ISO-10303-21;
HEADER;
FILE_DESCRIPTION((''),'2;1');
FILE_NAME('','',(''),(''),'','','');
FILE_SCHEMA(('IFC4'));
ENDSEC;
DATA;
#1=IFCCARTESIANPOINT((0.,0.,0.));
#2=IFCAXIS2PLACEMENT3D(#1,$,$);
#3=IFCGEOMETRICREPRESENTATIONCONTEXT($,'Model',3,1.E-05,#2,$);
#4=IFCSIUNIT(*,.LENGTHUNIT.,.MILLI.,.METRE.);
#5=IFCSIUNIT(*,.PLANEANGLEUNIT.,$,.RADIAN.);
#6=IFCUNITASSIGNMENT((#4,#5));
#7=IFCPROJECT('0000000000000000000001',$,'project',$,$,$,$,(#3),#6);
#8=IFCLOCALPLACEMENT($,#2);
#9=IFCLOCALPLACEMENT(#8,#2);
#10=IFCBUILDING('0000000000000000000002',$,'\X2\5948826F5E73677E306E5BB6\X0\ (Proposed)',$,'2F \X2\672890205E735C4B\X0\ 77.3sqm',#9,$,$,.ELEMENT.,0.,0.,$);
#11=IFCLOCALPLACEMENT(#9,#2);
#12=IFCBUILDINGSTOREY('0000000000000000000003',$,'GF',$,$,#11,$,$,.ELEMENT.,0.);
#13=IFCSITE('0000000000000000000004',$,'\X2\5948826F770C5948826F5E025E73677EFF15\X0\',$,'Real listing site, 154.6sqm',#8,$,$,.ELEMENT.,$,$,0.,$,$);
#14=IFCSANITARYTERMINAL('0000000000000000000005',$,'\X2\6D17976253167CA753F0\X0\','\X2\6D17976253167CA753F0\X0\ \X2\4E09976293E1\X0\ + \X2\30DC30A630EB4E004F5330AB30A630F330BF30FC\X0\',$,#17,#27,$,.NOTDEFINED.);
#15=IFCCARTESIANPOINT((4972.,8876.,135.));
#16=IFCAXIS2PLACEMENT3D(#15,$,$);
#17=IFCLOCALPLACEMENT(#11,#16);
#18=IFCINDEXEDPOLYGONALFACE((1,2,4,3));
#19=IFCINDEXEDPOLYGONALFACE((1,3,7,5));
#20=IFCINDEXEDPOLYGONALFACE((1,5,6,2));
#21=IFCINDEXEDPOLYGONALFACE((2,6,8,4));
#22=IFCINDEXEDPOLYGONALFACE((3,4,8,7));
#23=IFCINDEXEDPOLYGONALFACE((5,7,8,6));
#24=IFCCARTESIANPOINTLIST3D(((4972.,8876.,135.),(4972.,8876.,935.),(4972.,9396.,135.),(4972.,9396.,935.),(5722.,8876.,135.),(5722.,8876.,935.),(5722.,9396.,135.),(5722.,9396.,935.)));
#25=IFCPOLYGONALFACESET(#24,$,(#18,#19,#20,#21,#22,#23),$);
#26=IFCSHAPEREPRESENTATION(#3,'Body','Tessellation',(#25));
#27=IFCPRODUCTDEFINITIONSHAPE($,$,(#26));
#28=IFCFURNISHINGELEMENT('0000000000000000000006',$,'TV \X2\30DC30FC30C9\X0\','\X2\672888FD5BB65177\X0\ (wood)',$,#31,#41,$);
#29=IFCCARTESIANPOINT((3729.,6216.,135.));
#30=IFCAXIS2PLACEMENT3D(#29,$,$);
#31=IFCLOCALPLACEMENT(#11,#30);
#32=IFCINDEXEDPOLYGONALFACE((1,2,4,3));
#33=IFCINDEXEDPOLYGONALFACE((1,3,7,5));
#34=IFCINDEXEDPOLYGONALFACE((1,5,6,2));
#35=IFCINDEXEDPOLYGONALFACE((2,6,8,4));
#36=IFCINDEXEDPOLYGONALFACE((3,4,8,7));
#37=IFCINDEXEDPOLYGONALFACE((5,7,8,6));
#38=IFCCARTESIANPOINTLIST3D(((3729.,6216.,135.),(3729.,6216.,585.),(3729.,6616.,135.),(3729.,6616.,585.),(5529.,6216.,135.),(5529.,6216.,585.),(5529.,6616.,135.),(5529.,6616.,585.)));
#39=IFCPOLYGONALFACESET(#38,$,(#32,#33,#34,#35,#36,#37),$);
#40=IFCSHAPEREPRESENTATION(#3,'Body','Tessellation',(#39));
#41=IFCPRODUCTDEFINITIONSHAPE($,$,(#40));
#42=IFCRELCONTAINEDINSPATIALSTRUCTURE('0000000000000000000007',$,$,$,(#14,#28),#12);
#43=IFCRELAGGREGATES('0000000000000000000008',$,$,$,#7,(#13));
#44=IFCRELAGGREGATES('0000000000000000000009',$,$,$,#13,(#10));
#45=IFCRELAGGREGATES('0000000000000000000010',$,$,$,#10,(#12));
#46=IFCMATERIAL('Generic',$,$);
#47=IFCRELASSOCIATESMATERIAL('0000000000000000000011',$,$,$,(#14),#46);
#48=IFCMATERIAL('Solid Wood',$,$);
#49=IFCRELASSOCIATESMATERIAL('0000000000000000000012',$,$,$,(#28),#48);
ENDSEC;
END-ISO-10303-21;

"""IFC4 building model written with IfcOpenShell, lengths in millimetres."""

from ifc_helpers import new_model, si_unit, frame, frame_2d, origin, place, context, project, spatial, rectangle, extrude, material, element, save


model = new_model("IFC4")

# Units and contexts
model_context = context("Model", 3, precision=1e-05, world=origin())
ifc_project = project(units=[si_unit("LENGTHUNIT", "METRE", prefix="MILLI"), si_unit("PLANEANGLEUNIT", "RADIAN")], contexts=[model_context])

# Site, building, storey
site_placement = place(None, origin())
site = spatial("IfcSite", under=ifc_project, at=site_placement, Name="奈良県奈良市平松５", ObjectType="Real listing site, 154.6sqm", CompositionType="ELEMENT", RefElevation=0.0)
building_placement = place(site_placement, origin())
building = spatial("IfcBuilding", under=site, at=building_placement, Name="奈良平松の家 (Proposed)", ObjectType="2F 木造平屋 77.3sqm", CompositionType="ELEMENT", ElevationOfRefHeight=0.0, ElevationOfTerrain=0.0)
storey_placement = place(building_placement, origin())
storey = spatial("IfcBuildingStorey", under=building, at=storey_placement, Name="GF", CompositionType="ELEMENT", Elevation=0.0)

# Shared definitions
ifc_material_1 = material(Name="Solid Wood")

# Shared definitions
ifc_material_2 = material(Name="Generic")

# Sanitary terminal
sanitary_terminal_1_placement = place(storey_placement, frame((4972.0, 8876.0, 135.0)))
element("IfcSanitaryTerminal", 1, at=sanitary_terminal_1_placement, inside=storey, material=ifc_material_2, Name="洗面化粧台", Description="洗面化粧台 三面鏡 + ボウル一体カウンター", PredefinedType="NOTDEFINED", context=model_context, shape_type="SweptSolid", body=[
    extrude(rectangle(XDim=750.0, YDim=520.0, at=frame_2d((375.0, 260.0))), frame((4972.0, 8876.0, 135.0)), (0.0, 0.0, 1.0), 800.0),
])

# Furnishing element
furnishing_placement = place(storey_placement, frame((3729.0, 6216.0, 135.0)))
element("IfcFurnishingElement", 2, at=furnishing_placement, inside=storey, material=ifc_material_1, Name="TV ボード", Description="木製家具 (wood)", context=model_context, shape_type="SweptSolid", body=[
    extrude(rectangle(XDim=1800.0, YDim=400.0, at=frame_2d((900.0, 200.0))), frame((3729.0, 6216.0, 135.0)), (0.0, 0.0, 1.0), 450.0),
])

save(model, "model.ifc")
